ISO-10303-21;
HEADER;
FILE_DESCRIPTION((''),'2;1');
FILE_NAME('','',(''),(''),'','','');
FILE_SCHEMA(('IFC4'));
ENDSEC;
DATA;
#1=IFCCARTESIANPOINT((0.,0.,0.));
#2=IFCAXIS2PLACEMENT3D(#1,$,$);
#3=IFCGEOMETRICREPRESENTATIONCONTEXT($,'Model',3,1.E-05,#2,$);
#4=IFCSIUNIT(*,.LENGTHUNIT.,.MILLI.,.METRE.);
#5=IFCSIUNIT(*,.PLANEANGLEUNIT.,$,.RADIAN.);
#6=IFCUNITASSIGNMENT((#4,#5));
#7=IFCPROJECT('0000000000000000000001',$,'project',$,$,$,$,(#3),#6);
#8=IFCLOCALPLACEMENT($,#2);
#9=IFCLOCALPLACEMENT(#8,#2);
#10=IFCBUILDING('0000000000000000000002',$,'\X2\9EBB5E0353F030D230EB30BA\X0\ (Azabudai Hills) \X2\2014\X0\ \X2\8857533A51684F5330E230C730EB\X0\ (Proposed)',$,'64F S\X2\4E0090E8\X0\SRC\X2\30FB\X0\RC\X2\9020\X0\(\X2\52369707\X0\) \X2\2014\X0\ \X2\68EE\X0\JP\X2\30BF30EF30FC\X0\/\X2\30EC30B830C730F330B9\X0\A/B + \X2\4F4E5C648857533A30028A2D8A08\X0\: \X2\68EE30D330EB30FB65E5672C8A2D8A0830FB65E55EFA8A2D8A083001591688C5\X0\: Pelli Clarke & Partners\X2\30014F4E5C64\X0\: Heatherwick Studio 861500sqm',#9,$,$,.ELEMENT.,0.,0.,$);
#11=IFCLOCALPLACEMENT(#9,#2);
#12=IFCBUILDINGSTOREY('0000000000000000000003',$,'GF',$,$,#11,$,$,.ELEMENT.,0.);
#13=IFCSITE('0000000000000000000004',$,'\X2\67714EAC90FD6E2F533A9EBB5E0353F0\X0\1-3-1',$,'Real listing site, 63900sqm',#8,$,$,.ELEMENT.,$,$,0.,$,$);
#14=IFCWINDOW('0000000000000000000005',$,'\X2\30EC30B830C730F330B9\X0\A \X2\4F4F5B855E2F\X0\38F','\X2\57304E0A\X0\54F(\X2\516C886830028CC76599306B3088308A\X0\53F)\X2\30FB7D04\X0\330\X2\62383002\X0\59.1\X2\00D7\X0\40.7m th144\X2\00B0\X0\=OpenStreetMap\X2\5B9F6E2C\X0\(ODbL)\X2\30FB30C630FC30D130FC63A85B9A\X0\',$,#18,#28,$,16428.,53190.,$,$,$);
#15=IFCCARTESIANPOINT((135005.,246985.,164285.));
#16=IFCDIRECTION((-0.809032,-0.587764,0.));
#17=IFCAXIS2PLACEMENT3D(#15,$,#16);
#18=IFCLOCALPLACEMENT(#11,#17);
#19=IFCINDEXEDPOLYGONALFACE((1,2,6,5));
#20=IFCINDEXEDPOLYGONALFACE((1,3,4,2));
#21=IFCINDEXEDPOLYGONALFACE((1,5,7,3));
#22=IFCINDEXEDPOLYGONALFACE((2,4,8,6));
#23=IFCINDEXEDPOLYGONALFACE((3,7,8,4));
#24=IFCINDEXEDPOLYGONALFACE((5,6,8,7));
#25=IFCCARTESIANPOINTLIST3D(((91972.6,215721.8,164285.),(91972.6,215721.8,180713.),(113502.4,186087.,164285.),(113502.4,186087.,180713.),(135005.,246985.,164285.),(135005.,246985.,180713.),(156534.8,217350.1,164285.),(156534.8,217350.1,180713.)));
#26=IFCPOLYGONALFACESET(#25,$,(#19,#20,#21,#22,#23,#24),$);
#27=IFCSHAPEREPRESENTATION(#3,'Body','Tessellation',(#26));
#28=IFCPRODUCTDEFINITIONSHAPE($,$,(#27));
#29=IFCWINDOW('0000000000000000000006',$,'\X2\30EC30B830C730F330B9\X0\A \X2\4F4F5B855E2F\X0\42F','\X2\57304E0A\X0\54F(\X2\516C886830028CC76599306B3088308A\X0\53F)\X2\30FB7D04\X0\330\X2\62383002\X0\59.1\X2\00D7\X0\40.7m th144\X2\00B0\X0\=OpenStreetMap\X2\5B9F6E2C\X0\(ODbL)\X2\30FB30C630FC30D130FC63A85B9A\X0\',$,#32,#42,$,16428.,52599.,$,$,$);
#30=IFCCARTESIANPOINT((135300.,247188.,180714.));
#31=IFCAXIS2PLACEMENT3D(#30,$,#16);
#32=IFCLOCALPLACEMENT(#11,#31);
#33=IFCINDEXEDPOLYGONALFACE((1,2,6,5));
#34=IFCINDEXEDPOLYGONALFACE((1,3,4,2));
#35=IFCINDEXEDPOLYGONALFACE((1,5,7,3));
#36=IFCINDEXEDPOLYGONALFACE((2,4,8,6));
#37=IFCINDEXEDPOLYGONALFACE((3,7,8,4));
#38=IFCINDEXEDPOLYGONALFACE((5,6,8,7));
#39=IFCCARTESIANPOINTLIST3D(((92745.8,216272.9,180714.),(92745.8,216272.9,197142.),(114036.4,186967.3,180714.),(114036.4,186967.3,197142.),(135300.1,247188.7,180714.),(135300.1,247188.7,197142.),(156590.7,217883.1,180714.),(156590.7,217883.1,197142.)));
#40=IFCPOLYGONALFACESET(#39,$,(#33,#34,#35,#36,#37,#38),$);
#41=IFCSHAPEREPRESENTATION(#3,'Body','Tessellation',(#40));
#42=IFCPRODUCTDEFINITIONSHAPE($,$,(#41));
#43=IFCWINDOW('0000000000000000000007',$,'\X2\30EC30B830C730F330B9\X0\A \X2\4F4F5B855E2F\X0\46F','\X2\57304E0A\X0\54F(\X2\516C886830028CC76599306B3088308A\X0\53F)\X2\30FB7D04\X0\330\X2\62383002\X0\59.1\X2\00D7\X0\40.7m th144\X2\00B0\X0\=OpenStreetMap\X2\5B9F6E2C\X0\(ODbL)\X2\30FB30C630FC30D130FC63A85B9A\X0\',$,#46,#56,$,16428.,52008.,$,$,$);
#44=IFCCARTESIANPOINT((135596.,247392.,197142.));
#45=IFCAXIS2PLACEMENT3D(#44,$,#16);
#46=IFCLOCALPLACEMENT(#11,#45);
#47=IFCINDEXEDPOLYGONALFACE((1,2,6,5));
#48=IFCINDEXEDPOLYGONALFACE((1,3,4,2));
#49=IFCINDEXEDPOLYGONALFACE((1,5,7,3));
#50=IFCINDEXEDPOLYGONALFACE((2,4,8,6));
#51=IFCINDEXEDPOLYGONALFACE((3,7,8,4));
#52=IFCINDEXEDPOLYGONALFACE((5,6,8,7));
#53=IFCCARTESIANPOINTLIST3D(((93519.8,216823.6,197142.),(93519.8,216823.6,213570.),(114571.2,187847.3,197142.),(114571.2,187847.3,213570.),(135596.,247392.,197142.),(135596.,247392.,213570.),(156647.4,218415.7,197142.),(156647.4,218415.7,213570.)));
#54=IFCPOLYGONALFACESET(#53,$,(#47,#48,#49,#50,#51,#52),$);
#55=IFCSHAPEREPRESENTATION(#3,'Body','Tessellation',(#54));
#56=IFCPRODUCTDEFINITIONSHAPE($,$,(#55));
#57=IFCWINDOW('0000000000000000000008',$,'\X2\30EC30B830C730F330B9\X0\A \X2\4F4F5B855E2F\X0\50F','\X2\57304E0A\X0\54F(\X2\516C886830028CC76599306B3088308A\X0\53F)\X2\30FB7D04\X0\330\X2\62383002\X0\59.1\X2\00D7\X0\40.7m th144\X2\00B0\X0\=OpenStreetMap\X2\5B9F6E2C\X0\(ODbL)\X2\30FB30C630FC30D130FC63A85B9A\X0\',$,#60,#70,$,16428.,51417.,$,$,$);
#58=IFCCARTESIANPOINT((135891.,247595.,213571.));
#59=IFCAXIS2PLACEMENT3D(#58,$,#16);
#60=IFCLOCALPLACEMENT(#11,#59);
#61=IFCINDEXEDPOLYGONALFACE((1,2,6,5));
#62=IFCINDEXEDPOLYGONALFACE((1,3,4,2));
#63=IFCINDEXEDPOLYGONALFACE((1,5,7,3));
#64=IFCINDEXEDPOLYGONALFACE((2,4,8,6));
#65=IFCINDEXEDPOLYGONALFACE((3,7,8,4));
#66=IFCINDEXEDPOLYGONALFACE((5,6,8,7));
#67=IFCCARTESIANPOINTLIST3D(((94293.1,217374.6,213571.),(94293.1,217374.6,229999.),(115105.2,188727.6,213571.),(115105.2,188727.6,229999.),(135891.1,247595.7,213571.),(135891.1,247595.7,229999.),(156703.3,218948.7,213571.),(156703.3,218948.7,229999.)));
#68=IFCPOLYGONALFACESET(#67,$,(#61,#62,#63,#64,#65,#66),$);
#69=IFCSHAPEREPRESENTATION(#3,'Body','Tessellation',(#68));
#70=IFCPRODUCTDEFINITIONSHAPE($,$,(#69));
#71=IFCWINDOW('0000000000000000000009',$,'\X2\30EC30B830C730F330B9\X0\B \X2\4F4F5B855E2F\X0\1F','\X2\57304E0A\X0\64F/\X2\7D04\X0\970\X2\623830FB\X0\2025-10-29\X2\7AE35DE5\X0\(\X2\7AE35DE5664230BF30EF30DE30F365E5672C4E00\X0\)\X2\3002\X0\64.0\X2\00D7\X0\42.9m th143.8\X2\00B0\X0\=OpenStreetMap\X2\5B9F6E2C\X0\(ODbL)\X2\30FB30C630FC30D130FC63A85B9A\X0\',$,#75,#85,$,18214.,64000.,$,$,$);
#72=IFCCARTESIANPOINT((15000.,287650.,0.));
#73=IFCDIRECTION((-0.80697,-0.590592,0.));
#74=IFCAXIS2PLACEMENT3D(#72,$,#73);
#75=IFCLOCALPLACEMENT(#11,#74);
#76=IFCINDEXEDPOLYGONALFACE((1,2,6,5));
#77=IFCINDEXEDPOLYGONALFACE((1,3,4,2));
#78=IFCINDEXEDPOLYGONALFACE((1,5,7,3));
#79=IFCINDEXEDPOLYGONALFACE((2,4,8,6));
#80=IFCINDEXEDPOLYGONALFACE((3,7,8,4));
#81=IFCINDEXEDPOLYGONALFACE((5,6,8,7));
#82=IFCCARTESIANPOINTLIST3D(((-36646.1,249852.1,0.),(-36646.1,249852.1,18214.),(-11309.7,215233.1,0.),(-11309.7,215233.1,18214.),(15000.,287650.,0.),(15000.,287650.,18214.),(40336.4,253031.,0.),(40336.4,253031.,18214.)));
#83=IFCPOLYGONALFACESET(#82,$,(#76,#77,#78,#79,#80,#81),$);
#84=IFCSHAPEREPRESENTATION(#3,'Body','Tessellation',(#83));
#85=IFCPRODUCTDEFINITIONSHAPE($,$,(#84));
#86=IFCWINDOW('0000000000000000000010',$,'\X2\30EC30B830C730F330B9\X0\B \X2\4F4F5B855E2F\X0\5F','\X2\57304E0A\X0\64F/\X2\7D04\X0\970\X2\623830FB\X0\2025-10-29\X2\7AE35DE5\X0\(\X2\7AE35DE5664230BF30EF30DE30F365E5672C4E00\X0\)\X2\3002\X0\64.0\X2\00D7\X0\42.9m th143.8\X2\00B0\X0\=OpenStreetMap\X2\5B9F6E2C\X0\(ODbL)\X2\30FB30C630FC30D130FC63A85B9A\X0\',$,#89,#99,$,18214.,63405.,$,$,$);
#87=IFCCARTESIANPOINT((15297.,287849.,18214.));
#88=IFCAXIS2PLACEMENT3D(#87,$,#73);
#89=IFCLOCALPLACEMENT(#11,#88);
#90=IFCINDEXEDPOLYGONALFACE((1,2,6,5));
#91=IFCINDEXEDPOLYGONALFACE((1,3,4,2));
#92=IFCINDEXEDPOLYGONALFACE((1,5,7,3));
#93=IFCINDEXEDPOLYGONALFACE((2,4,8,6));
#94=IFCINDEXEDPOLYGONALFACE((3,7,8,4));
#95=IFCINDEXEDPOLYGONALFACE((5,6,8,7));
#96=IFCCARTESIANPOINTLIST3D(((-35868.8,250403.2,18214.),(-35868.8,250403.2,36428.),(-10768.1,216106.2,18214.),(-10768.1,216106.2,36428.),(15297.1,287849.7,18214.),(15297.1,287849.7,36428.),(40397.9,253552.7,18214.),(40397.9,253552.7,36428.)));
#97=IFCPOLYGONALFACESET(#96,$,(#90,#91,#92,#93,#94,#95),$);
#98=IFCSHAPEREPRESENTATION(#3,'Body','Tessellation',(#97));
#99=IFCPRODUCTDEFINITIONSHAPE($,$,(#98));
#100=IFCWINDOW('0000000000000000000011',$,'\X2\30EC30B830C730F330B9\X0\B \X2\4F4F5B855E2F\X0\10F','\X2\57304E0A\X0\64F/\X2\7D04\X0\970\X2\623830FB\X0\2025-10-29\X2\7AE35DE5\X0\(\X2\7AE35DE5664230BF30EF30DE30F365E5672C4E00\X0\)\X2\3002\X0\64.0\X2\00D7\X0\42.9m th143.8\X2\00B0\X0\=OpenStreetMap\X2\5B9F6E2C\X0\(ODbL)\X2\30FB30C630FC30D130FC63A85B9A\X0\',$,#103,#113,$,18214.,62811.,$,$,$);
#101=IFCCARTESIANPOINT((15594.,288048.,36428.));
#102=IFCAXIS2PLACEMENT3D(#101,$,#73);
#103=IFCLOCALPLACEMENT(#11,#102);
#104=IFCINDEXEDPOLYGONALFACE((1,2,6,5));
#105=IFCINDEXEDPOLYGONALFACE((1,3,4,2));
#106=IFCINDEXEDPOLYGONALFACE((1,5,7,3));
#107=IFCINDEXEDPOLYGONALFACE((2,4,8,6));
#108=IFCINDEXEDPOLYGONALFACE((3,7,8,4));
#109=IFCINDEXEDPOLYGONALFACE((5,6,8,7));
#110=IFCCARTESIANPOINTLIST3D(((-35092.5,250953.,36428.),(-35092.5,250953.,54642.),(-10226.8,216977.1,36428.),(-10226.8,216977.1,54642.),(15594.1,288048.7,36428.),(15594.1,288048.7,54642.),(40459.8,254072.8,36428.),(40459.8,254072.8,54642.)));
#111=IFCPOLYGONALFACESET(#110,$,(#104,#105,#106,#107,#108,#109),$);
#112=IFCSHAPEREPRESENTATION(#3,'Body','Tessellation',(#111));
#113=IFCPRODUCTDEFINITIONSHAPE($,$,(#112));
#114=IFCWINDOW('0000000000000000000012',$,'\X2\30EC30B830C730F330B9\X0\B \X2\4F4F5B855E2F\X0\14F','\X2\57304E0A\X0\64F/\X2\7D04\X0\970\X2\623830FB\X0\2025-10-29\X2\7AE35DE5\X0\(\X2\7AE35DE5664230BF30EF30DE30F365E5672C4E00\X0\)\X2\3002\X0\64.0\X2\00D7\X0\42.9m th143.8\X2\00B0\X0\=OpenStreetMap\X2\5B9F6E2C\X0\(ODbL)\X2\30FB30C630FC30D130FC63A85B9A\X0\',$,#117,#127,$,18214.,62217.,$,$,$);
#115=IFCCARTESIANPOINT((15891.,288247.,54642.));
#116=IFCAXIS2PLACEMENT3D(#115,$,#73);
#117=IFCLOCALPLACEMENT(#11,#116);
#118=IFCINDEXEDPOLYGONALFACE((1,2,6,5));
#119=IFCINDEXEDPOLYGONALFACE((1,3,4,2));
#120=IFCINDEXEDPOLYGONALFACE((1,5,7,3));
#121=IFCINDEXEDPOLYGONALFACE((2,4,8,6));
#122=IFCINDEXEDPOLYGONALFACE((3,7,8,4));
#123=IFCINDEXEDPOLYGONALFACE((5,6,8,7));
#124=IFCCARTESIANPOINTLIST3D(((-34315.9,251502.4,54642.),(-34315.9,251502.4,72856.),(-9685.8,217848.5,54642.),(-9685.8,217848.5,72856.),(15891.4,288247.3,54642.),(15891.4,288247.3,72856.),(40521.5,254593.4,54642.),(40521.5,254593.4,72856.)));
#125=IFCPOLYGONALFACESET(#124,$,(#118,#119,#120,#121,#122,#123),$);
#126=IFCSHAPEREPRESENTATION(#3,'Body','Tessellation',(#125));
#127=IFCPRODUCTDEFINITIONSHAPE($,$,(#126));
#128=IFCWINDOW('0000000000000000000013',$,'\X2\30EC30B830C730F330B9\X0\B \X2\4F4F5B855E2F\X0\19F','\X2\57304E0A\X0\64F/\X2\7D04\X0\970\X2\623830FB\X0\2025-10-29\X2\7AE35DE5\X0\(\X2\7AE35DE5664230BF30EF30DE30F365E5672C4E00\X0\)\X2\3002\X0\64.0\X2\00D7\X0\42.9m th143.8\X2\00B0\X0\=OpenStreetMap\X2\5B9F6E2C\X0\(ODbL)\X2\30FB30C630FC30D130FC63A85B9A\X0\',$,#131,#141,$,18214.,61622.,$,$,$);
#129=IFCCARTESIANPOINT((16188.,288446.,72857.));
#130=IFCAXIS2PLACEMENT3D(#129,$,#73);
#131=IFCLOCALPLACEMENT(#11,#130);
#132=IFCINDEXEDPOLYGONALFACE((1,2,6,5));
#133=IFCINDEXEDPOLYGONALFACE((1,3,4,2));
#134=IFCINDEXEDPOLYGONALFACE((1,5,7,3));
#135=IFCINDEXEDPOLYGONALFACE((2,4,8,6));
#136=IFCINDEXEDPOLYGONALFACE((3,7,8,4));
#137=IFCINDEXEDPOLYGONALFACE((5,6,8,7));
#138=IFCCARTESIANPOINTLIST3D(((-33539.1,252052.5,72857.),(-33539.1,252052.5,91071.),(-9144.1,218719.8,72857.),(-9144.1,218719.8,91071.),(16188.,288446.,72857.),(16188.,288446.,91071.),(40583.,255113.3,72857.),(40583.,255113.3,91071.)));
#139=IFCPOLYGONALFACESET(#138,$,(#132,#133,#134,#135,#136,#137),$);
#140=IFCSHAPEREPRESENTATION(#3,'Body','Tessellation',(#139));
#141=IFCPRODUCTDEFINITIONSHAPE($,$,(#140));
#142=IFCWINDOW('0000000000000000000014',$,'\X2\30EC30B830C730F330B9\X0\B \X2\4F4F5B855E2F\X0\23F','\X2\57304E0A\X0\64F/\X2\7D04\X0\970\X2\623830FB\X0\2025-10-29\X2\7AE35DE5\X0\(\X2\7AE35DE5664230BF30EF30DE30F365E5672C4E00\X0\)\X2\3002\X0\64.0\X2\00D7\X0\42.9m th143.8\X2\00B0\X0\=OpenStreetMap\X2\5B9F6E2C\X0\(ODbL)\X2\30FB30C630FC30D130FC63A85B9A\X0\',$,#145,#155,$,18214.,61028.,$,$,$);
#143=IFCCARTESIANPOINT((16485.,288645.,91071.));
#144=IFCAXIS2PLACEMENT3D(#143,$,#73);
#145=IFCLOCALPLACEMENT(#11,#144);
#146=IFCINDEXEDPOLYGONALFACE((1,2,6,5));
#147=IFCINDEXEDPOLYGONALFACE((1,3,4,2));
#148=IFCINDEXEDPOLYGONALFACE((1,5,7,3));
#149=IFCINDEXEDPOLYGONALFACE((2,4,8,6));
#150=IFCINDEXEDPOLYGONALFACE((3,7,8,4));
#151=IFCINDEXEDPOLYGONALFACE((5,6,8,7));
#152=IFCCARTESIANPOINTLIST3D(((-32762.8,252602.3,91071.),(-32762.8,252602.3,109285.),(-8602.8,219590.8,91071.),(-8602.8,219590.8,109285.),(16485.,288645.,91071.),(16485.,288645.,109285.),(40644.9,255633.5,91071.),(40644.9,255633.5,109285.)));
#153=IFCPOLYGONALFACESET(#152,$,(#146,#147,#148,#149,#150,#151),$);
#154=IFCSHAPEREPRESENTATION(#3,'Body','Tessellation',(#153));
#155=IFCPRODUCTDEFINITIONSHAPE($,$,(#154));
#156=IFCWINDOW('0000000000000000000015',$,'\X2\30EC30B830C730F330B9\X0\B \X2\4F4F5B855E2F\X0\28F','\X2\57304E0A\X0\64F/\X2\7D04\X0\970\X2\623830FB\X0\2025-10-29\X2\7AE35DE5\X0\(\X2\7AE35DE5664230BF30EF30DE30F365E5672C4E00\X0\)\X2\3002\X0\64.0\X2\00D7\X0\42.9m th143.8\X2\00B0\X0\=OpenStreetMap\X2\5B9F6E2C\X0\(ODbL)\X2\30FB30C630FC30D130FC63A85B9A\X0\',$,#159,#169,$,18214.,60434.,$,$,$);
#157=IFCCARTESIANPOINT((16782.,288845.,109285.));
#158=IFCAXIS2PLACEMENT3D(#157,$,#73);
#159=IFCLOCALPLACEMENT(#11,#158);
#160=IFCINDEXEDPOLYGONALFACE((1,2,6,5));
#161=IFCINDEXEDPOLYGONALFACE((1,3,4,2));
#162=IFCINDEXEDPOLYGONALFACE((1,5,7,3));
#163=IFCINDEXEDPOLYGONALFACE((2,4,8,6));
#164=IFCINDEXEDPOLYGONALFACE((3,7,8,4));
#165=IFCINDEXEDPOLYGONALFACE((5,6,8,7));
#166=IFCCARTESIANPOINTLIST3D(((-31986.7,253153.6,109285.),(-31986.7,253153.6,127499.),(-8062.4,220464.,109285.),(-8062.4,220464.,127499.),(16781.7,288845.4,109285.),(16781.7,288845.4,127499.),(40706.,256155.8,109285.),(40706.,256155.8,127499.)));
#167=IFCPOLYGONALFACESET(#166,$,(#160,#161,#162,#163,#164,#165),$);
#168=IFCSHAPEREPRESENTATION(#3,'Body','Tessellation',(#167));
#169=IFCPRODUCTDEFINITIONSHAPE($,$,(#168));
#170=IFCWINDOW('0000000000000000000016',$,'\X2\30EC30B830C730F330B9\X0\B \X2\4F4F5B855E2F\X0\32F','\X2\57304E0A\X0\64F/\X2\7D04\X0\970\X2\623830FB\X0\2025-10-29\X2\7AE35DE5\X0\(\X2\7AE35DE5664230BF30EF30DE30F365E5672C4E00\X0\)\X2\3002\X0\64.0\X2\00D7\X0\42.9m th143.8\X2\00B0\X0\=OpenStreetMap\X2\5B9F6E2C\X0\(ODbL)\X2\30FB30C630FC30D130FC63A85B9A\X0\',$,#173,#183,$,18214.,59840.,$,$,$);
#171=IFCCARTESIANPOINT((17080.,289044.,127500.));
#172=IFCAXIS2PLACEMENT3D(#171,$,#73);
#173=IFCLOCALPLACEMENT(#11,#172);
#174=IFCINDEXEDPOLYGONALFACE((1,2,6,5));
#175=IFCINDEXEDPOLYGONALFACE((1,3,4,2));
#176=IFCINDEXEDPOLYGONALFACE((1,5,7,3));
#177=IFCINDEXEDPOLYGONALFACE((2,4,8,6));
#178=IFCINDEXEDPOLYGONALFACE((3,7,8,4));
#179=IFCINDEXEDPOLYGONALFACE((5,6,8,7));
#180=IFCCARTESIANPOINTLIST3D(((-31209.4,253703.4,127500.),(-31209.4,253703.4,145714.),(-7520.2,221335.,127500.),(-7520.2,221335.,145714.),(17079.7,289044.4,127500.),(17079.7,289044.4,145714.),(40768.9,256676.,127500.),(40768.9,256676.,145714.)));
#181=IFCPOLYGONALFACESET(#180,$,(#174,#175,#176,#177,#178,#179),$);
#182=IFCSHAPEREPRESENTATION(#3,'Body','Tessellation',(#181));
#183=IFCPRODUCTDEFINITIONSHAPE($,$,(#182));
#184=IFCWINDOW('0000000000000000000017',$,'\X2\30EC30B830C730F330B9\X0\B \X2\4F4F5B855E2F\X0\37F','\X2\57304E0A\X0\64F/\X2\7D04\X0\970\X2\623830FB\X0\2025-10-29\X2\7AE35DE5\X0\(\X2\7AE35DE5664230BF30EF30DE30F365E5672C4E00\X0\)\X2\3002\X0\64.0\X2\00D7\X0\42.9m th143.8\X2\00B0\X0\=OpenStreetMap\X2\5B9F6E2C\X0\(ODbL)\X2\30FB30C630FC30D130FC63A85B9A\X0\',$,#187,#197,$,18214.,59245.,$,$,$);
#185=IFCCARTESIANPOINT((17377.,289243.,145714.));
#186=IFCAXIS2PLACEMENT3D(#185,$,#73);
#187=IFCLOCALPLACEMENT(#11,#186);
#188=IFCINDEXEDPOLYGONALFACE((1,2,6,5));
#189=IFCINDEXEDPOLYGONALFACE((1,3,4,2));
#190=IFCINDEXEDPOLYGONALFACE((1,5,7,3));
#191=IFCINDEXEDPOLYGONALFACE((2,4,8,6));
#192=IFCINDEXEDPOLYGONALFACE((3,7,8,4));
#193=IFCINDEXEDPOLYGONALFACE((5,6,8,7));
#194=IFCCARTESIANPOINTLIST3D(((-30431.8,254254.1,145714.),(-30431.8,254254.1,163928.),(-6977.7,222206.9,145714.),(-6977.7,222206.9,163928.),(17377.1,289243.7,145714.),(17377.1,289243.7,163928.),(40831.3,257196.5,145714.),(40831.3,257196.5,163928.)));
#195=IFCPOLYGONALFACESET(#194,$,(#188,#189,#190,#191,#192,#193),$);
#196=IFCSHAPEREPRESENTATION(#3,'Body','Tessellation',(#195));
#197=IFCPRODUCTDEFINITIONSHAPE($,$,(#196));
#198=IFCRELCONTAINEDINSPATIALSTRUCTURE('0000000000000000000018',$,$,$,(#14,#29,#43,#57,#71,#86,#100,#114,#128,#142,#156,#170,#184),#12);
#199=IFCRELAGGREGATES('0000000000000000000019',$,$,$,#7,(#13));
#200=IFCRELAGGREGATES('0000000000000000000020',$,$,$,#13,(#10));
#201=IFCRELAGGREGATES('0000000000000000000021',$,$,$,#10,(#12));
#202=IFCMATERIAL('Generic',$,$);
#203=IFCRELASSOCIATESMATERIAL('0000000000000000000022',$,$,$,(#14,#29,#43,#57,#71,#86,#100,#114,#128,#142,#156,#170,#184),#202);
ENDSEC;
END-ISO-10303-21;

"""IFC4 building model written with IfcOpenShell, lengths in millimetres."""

from ifc_helpers import new_model, si_unit, frame, frame_2d, origin, place, context, project, spatial, rectangle, extrude, material, element, save


model = new_model("IFC4")

# Units and contexts
model_context = context("Model", 3, precision=1e-05, world=origin())
ifc_project = project(units=[si_unit("LENGTHUNIT", "METRE", prefix="MILLI"), si_unit("PLANEANGLEUNIT", "RADIAN")], contexts=[model_context])

# Site, building, storey
site_placement = place(None, origin())
site = spatial("IfcSite", under=ifc_project, at=site_placement, Name="東京都港区麻布台1-3-1", ObjectType="Real listing site, 63900sqm", CompositionType="ELEMENT", RefElevation=0.0)
building_placement = place(site_placement, origin())
building = spatial("IfcBuilding", under=site, at=building_placement, Name="麻布台ヒルズ (Azabudai Hills) — 街区全体モデル (Proposed)", ObjectType="64F S一部SRC・RC造(制震) — 森JPタワー/レジデンスA/B + 低層街区。設計: 森ビル・日本設計・日建設計、外装: Pelli Clarke & Partners、低層: Heatherwick Studio 861500sqm", CompositionType="ELEMENT", ElevationOfRefHeight=0.0, ElevationOfTerrain=0.0)
storey_placement = place(building_placement, origin())
storey = spatial("IfcBuildingStorey", under=building, at=storey_placement, Name="GF", CompositionType="ELEMENT", Elevation=0.0)

# Windows
ifc_material = material(Name="Generic")
window_1_placement = place(storey_placement, frame((135005.0, 246985.0, 164285.0), x_axis=(-0.809032, -0.587764, 0.0)))
element("IfcWindow", 1, at=window_1_placement, inside=storey, material=ifc_material, Name="レジデンスA 住宅帯38F", Description="地上54F(公表。資料により53F)・約330戸。59.1×40.7m th144°=OpenStreetMap実測(ODbL)・テーパー推定", OverallHeight=16428.0, OverallWidth=53190.0, context=model_context, shape_type="SweptSolid", body=[
    extrude(rectangle(XDim=53190.0, YDim=36630.0, at=frame_2d((26595.0, 18315.0))), frame((135005.0, 246985.0, 164285.0), x_axis=(-0.809032, -0.587764, 0.0)), (0.0, 0.0, 1.0), 16428.0),
])
window_2_placement = place(storey_placement, frame((135300.0, 247188.0, 180714.0), x_axis=(-0.809032, -0.587764, 0.0)))
element("IfcWindow", 2, at=window_2_placement, inside=storey, material=ifc_material, Name="レジデンスA 住宅帯42F", Description="地上54F(公表。資料により53F)・約330戸。59.1×40.7m th144°=OpenStreetMap実測(ODbL)・テーパー推定", OverallHeight=16428.0, OverallWidth=52599.0, context=model_context, shape_type="SweptSolid", body=[
    extrude(rectangle(XDim=52599.0, YDim=36223.0, at=frame_2d((26299.0, 18111.0))), frame((135300.0, 247188.0, 180714.0), x_axis=(-0.809032, -0.587764, 0.0)), (0.0, 0.0, 1.0), 16428.0),
])
window_3_placement = place(storey_placement, frame((135596.0, 247392.0, 197142.0), x_axis=(-0.809032, -0.587764, 0.0)))
element("IfcWindow", 3, at=window_3_placement, inside=storey, material=ifc_material, Name="レジデンスA 住宅帯46F", Description="地上54F(公表。資料により53F)・約330戸。59.1×40.7m th144°=OpenStreetMap実測(ODbL)・テーパー推定", OverallHeight=16428.0, OverallWidth=52008.0, context=model_context, shape_type="SweptSolid", body=[
    extrude(rectangle(XDim=52008.0, YDim=35816.0, at=frame_2d((26004.0, 17908.0))), frame((135596.0, 247392.0, 197142.0), x_axis=(-0.809032, -0.587764, 0.0)), (0.0, 0.0, 1.0), 16428.0),
])
window_4_placement = place(storey_placement, frame((135891.0, 247595.0, 213571.0), x_axis=(-0.809032, -0.587764, 0.0)))
element("IfcWindow", 4, at=window_4_placement, inside=storey, material=ifc_material, Name="レジデンスA 住宅帯50F", Description="地上54F(公表。資料により53F)・約330戸。59.1×40.7m th144°=OpenStreetMap実測(ODbL)・テーパー推定", OverallHeight=16428.0, OverallWidth=51417.0, context=model_context, shape_type="SweptSolid", body=[
    extrude(rectangle(XDim=51417.0, YDim=35409.0, at=frame_2d((25708.0, 17704.0))), frame((135891.0, 247595.0, 213571.0), x_axis=(-0.809032, -0.587764, 0.0)), (0.0, 0.0, 1.0), 16428.0),
])
window_5_placement = place(storey_placement, frame((15000.0, 287650.0, 0.0), x_axis=(-0.80697, -0.590592, 0.0)))
element("IfcWindow", 5, at=window_5_placement, inside=storey, material=ifc_material, Name="レジデンスB 住宅帯1F", Description="地上64F/約970戸・2025-10-29竣工(竣工時タワマン日本一)。64.0×42.9m th143.8°=OpenStreetMap実測(ODbL)・テーパー推定", OverallHeight=18214.0, OverallWidth=64000.0, context=model_context, shape_type="SweptSolid", body=[
    extrude(rectangle(XDim=64000.0, YDim=42900.0, at=frame_2d((32000.0, 21450.0))), frame((15000.0, 287650.0, 0.0), x_axis=(-0.80697, -0.590592, 0.0)), (0.0, 0.0, 1.0), 18214.0),
])
window_6_placement = place(storey_placement, frame((15297.0, 287849.0, 18214.0), x_axis=(-0.80697, -0.590592, 0.0)))
element("IfcWindow", 6, at=window_6_placement, inside=storey, material=ifc_material, Name="レジデンスB 住宅帯5F", Description="地上64F/約970戸・2025-10-29竣工(竣工時タワマン日本一)。64.0×42.9m th143.8°=OpenStreetMap実測(ODbL)・テーパー推定", OverallHeight=18214.0, OverallWidth=63405.0, context=model_context, shape_type="SweptSolid", body=[
    extrude(rectangle(XDim=63405.0, YDim=42501.0, at=frame_2d((31702.0, 21250.0))), frame((15297.0, 287849.0, 18214.0), x_axis=(-0.80697, -0.590592, 0.0)), (0.0, 0.0, 1.0), 18214.0),
])
window_7_placement = place(storey_placement, frame((15594.0, 288048.0, 36428.0), x_axis=(-0.80697, -0.590592, 0.0)))
element("IfcWindow", 7, at=window_7_placement, inside=storey, material=ifc_material, Name="レジデンスB 住宅帯10F", Description="地上64F/約970戸・2025-10-29竣工(竣工時タワマン日本一)。64.0×42.9m th143.8°=OpenStreetMap実測(ODbL)・テーパー推定", OverallHeight=18214.0, OverallWidth=62811.0, context=model_context, shape_type="SweptSolid", body=[
    extrude(rectangle(XDim=62811.0, YDim=42103.0, at=frame_2d((31405.0, 21051.0))), frame((15594.0, 288048.0, 36428.0), x_axis=(-0.80697, -0.590592, 0.0)), (0.0, 0.0, 1.0), 18214.0),
])
window_8_placement = place(storey_placement, frame((15891.0, 288247.0, 54642.0), x_axis=(-0.80697, -0.590592, 0.0)))
element("IfcWindow", 8, at=window_8_placement, inside=storey, material=ifc_material, Name="レジデンスB 住宅帯14F", Description="地上64F/約970戸・2025-10-29竣工(竣工時タワマン日本一)。64.0×42.9m th143.8°=OpenStreetMap実測(ODbL)・テーパー推定", OverallHeight=18214.0, OverallWidth=62217.0, context=model_context, shape_type="SweptSolid", body=[
    extrude(rectangle(XDim=62217.0, YDim=41704.0, at=frame_2d((31108.0, 20852.0))), frame((15891.0, 288247.0, 54642.0), x_axis=(-0.80697, -0.590592, 0.0)), (0.0, 0.0, 1.0), 18214.0),
])
window_9_placement = place(storey_placement, frame((16188.0, 288446.0, 72857.0), x_axis=(-0.80697, -0.590592, 0.0)))
element("IfcWindow", 9, at=window_9_placement, inside=storey, material=ifc_material, Name="レジデンスB 住宅帯19F", Description="地上64F/約970戸・2025-10-29竣工(竣工時タワマン日本一)。64.0×42.9m th143.8°=OpenStreetMap実測(ODbL)・テーパー推定", OverallHeight=18214.0, OverallWidth=61622.0, context=model_context, shape_type="SweptSolid", body=[
    extrude(rectangle(XDim=61622.0, YDim=41306.0, at=frame_2d((30811.0, 20653.0))), frame((16188.0, 288446.0, 72857.0), x_axis=(-0.80697, -0.590592, 0.0)), (0.0, 0.0, 1.0), 18214.0),
])
window_10_placement = place(storey_placement, frame((16485.0, 288645.0, 91071.0), x_axis=(-0.80697, -0.590592, 0.0)))
element("IfcWindow", 10, at=window_10_placement, inside=storey, material=ifc_material, Name="レジデンスB 住宅帯23F", Description="地上64F/約970戸・2025-10-29竣工(竣工時タワマン日本一)。64.0×42.9m th143.8°=OpenStreetMap実測(ODbL)・テーパー推定", OverallHeight=18214.0, OverallWidth=61028.0, context=model_context, shape_type="SweptSolid", body=[
    extrude(rectangle(XDim=61028.0, YDim=40908.0, at=frame_2d((30514.0, 20454.0))), frame((16485.0, 288645.0, 91071.0), x_axis=(-0.80697, -0.590592, 0.0)), (0.0, 0.0, 1.0), 18214.0),
])
window_11_placement = place(storey_placement, frame((16782.0, 288845.0, 109285.0), x_axis=(-0.80697, -0.590592, 0.0)))
element("IfcWindow", 11, at=window_11_placement, inside=storey, material=ifc_material, Name="レジデンスB 住宅帯28F", Description="地上64F/約970戸・2025-10-29竣工(竣工時タワマン日本一)。64.0×42.9m th143.8°=OpenStreetMap実測(ODbL)・テーパー推定", OverallHeight=18214.0, OverallWidth=60434.0, context=model_context, shape_type="SweptSolid", body=[
    extrude(rectangle(XDim=60434.0, YDim=40509.0, at=frame_2d((30217.0, 20254.0))), frame((16782.0, 288845.0, 109285.0), x_axis=(-0.80697, -0.590592, 0.0)), (0.0, 0.0, 1.0), 18214.0),
])
window_12_placement = place(storey_placement, frame((17080.0, 289044.0, 127500.0), x_axis=(-0.80697, -0.590592, 0.0)))
element("IfcWindow", 12, at=window_12_placement, inside=storey, material=ifc_material, Name="レジデンスB 住宅帯32F", Description="地上64F/約970戸・2025-10-29竣工(竣工時タワマン日本一)。64.0×42.9m th143.8°=OpenStreetMap実測(ODbL)・テーパー推定", OverallHeight=18214.0, OverallWidth=59840.0, context=model_context, shape_type="SweptSolid", body=[
    extrude(rectangle(XDim=59840.0, YDim=40111.0, at=frame_2d((29920.0, 20055.0))), frame((17080.0, 289044.0, 127500.0), x_axis=(-0.80697, -0.590592, 0.0)), (0.0, 0.0, 1.0), 18214.0),
])
window_13_placement = place(storey_placement, frame((17377.0, 289243.0, 145714.0), x_axis=(-0.80697, -0.590592, 0.0)))
element("IfcWindow", 13, at=window_13_placement, inside=storey, material=ifc_material, Name="レジデンスB 住宅帯37F", Description="地上64F/約970戸・2025-10-29竣工(竣工時タワマン日本一)。64.0×42.9m th143.8°=OpenStreetMap実測(ODbL)・テーパー推定", OverallHeight=18214.0, OverallWidth=59245.0, context=model_context, shape_type="SweptSolid", body=[
    extrude(rectangle(XDim=59245.0, YDim=39713.0, at=frame_2d((29622.0, 19856.0))), frame((17377.0, 289243.0, 145714.0), x_axis=(-0.80697, -0.590592, 0.0)), (0.0, 0.0, 1.0), 18214.0),
])

save(model, "model.ifc")
